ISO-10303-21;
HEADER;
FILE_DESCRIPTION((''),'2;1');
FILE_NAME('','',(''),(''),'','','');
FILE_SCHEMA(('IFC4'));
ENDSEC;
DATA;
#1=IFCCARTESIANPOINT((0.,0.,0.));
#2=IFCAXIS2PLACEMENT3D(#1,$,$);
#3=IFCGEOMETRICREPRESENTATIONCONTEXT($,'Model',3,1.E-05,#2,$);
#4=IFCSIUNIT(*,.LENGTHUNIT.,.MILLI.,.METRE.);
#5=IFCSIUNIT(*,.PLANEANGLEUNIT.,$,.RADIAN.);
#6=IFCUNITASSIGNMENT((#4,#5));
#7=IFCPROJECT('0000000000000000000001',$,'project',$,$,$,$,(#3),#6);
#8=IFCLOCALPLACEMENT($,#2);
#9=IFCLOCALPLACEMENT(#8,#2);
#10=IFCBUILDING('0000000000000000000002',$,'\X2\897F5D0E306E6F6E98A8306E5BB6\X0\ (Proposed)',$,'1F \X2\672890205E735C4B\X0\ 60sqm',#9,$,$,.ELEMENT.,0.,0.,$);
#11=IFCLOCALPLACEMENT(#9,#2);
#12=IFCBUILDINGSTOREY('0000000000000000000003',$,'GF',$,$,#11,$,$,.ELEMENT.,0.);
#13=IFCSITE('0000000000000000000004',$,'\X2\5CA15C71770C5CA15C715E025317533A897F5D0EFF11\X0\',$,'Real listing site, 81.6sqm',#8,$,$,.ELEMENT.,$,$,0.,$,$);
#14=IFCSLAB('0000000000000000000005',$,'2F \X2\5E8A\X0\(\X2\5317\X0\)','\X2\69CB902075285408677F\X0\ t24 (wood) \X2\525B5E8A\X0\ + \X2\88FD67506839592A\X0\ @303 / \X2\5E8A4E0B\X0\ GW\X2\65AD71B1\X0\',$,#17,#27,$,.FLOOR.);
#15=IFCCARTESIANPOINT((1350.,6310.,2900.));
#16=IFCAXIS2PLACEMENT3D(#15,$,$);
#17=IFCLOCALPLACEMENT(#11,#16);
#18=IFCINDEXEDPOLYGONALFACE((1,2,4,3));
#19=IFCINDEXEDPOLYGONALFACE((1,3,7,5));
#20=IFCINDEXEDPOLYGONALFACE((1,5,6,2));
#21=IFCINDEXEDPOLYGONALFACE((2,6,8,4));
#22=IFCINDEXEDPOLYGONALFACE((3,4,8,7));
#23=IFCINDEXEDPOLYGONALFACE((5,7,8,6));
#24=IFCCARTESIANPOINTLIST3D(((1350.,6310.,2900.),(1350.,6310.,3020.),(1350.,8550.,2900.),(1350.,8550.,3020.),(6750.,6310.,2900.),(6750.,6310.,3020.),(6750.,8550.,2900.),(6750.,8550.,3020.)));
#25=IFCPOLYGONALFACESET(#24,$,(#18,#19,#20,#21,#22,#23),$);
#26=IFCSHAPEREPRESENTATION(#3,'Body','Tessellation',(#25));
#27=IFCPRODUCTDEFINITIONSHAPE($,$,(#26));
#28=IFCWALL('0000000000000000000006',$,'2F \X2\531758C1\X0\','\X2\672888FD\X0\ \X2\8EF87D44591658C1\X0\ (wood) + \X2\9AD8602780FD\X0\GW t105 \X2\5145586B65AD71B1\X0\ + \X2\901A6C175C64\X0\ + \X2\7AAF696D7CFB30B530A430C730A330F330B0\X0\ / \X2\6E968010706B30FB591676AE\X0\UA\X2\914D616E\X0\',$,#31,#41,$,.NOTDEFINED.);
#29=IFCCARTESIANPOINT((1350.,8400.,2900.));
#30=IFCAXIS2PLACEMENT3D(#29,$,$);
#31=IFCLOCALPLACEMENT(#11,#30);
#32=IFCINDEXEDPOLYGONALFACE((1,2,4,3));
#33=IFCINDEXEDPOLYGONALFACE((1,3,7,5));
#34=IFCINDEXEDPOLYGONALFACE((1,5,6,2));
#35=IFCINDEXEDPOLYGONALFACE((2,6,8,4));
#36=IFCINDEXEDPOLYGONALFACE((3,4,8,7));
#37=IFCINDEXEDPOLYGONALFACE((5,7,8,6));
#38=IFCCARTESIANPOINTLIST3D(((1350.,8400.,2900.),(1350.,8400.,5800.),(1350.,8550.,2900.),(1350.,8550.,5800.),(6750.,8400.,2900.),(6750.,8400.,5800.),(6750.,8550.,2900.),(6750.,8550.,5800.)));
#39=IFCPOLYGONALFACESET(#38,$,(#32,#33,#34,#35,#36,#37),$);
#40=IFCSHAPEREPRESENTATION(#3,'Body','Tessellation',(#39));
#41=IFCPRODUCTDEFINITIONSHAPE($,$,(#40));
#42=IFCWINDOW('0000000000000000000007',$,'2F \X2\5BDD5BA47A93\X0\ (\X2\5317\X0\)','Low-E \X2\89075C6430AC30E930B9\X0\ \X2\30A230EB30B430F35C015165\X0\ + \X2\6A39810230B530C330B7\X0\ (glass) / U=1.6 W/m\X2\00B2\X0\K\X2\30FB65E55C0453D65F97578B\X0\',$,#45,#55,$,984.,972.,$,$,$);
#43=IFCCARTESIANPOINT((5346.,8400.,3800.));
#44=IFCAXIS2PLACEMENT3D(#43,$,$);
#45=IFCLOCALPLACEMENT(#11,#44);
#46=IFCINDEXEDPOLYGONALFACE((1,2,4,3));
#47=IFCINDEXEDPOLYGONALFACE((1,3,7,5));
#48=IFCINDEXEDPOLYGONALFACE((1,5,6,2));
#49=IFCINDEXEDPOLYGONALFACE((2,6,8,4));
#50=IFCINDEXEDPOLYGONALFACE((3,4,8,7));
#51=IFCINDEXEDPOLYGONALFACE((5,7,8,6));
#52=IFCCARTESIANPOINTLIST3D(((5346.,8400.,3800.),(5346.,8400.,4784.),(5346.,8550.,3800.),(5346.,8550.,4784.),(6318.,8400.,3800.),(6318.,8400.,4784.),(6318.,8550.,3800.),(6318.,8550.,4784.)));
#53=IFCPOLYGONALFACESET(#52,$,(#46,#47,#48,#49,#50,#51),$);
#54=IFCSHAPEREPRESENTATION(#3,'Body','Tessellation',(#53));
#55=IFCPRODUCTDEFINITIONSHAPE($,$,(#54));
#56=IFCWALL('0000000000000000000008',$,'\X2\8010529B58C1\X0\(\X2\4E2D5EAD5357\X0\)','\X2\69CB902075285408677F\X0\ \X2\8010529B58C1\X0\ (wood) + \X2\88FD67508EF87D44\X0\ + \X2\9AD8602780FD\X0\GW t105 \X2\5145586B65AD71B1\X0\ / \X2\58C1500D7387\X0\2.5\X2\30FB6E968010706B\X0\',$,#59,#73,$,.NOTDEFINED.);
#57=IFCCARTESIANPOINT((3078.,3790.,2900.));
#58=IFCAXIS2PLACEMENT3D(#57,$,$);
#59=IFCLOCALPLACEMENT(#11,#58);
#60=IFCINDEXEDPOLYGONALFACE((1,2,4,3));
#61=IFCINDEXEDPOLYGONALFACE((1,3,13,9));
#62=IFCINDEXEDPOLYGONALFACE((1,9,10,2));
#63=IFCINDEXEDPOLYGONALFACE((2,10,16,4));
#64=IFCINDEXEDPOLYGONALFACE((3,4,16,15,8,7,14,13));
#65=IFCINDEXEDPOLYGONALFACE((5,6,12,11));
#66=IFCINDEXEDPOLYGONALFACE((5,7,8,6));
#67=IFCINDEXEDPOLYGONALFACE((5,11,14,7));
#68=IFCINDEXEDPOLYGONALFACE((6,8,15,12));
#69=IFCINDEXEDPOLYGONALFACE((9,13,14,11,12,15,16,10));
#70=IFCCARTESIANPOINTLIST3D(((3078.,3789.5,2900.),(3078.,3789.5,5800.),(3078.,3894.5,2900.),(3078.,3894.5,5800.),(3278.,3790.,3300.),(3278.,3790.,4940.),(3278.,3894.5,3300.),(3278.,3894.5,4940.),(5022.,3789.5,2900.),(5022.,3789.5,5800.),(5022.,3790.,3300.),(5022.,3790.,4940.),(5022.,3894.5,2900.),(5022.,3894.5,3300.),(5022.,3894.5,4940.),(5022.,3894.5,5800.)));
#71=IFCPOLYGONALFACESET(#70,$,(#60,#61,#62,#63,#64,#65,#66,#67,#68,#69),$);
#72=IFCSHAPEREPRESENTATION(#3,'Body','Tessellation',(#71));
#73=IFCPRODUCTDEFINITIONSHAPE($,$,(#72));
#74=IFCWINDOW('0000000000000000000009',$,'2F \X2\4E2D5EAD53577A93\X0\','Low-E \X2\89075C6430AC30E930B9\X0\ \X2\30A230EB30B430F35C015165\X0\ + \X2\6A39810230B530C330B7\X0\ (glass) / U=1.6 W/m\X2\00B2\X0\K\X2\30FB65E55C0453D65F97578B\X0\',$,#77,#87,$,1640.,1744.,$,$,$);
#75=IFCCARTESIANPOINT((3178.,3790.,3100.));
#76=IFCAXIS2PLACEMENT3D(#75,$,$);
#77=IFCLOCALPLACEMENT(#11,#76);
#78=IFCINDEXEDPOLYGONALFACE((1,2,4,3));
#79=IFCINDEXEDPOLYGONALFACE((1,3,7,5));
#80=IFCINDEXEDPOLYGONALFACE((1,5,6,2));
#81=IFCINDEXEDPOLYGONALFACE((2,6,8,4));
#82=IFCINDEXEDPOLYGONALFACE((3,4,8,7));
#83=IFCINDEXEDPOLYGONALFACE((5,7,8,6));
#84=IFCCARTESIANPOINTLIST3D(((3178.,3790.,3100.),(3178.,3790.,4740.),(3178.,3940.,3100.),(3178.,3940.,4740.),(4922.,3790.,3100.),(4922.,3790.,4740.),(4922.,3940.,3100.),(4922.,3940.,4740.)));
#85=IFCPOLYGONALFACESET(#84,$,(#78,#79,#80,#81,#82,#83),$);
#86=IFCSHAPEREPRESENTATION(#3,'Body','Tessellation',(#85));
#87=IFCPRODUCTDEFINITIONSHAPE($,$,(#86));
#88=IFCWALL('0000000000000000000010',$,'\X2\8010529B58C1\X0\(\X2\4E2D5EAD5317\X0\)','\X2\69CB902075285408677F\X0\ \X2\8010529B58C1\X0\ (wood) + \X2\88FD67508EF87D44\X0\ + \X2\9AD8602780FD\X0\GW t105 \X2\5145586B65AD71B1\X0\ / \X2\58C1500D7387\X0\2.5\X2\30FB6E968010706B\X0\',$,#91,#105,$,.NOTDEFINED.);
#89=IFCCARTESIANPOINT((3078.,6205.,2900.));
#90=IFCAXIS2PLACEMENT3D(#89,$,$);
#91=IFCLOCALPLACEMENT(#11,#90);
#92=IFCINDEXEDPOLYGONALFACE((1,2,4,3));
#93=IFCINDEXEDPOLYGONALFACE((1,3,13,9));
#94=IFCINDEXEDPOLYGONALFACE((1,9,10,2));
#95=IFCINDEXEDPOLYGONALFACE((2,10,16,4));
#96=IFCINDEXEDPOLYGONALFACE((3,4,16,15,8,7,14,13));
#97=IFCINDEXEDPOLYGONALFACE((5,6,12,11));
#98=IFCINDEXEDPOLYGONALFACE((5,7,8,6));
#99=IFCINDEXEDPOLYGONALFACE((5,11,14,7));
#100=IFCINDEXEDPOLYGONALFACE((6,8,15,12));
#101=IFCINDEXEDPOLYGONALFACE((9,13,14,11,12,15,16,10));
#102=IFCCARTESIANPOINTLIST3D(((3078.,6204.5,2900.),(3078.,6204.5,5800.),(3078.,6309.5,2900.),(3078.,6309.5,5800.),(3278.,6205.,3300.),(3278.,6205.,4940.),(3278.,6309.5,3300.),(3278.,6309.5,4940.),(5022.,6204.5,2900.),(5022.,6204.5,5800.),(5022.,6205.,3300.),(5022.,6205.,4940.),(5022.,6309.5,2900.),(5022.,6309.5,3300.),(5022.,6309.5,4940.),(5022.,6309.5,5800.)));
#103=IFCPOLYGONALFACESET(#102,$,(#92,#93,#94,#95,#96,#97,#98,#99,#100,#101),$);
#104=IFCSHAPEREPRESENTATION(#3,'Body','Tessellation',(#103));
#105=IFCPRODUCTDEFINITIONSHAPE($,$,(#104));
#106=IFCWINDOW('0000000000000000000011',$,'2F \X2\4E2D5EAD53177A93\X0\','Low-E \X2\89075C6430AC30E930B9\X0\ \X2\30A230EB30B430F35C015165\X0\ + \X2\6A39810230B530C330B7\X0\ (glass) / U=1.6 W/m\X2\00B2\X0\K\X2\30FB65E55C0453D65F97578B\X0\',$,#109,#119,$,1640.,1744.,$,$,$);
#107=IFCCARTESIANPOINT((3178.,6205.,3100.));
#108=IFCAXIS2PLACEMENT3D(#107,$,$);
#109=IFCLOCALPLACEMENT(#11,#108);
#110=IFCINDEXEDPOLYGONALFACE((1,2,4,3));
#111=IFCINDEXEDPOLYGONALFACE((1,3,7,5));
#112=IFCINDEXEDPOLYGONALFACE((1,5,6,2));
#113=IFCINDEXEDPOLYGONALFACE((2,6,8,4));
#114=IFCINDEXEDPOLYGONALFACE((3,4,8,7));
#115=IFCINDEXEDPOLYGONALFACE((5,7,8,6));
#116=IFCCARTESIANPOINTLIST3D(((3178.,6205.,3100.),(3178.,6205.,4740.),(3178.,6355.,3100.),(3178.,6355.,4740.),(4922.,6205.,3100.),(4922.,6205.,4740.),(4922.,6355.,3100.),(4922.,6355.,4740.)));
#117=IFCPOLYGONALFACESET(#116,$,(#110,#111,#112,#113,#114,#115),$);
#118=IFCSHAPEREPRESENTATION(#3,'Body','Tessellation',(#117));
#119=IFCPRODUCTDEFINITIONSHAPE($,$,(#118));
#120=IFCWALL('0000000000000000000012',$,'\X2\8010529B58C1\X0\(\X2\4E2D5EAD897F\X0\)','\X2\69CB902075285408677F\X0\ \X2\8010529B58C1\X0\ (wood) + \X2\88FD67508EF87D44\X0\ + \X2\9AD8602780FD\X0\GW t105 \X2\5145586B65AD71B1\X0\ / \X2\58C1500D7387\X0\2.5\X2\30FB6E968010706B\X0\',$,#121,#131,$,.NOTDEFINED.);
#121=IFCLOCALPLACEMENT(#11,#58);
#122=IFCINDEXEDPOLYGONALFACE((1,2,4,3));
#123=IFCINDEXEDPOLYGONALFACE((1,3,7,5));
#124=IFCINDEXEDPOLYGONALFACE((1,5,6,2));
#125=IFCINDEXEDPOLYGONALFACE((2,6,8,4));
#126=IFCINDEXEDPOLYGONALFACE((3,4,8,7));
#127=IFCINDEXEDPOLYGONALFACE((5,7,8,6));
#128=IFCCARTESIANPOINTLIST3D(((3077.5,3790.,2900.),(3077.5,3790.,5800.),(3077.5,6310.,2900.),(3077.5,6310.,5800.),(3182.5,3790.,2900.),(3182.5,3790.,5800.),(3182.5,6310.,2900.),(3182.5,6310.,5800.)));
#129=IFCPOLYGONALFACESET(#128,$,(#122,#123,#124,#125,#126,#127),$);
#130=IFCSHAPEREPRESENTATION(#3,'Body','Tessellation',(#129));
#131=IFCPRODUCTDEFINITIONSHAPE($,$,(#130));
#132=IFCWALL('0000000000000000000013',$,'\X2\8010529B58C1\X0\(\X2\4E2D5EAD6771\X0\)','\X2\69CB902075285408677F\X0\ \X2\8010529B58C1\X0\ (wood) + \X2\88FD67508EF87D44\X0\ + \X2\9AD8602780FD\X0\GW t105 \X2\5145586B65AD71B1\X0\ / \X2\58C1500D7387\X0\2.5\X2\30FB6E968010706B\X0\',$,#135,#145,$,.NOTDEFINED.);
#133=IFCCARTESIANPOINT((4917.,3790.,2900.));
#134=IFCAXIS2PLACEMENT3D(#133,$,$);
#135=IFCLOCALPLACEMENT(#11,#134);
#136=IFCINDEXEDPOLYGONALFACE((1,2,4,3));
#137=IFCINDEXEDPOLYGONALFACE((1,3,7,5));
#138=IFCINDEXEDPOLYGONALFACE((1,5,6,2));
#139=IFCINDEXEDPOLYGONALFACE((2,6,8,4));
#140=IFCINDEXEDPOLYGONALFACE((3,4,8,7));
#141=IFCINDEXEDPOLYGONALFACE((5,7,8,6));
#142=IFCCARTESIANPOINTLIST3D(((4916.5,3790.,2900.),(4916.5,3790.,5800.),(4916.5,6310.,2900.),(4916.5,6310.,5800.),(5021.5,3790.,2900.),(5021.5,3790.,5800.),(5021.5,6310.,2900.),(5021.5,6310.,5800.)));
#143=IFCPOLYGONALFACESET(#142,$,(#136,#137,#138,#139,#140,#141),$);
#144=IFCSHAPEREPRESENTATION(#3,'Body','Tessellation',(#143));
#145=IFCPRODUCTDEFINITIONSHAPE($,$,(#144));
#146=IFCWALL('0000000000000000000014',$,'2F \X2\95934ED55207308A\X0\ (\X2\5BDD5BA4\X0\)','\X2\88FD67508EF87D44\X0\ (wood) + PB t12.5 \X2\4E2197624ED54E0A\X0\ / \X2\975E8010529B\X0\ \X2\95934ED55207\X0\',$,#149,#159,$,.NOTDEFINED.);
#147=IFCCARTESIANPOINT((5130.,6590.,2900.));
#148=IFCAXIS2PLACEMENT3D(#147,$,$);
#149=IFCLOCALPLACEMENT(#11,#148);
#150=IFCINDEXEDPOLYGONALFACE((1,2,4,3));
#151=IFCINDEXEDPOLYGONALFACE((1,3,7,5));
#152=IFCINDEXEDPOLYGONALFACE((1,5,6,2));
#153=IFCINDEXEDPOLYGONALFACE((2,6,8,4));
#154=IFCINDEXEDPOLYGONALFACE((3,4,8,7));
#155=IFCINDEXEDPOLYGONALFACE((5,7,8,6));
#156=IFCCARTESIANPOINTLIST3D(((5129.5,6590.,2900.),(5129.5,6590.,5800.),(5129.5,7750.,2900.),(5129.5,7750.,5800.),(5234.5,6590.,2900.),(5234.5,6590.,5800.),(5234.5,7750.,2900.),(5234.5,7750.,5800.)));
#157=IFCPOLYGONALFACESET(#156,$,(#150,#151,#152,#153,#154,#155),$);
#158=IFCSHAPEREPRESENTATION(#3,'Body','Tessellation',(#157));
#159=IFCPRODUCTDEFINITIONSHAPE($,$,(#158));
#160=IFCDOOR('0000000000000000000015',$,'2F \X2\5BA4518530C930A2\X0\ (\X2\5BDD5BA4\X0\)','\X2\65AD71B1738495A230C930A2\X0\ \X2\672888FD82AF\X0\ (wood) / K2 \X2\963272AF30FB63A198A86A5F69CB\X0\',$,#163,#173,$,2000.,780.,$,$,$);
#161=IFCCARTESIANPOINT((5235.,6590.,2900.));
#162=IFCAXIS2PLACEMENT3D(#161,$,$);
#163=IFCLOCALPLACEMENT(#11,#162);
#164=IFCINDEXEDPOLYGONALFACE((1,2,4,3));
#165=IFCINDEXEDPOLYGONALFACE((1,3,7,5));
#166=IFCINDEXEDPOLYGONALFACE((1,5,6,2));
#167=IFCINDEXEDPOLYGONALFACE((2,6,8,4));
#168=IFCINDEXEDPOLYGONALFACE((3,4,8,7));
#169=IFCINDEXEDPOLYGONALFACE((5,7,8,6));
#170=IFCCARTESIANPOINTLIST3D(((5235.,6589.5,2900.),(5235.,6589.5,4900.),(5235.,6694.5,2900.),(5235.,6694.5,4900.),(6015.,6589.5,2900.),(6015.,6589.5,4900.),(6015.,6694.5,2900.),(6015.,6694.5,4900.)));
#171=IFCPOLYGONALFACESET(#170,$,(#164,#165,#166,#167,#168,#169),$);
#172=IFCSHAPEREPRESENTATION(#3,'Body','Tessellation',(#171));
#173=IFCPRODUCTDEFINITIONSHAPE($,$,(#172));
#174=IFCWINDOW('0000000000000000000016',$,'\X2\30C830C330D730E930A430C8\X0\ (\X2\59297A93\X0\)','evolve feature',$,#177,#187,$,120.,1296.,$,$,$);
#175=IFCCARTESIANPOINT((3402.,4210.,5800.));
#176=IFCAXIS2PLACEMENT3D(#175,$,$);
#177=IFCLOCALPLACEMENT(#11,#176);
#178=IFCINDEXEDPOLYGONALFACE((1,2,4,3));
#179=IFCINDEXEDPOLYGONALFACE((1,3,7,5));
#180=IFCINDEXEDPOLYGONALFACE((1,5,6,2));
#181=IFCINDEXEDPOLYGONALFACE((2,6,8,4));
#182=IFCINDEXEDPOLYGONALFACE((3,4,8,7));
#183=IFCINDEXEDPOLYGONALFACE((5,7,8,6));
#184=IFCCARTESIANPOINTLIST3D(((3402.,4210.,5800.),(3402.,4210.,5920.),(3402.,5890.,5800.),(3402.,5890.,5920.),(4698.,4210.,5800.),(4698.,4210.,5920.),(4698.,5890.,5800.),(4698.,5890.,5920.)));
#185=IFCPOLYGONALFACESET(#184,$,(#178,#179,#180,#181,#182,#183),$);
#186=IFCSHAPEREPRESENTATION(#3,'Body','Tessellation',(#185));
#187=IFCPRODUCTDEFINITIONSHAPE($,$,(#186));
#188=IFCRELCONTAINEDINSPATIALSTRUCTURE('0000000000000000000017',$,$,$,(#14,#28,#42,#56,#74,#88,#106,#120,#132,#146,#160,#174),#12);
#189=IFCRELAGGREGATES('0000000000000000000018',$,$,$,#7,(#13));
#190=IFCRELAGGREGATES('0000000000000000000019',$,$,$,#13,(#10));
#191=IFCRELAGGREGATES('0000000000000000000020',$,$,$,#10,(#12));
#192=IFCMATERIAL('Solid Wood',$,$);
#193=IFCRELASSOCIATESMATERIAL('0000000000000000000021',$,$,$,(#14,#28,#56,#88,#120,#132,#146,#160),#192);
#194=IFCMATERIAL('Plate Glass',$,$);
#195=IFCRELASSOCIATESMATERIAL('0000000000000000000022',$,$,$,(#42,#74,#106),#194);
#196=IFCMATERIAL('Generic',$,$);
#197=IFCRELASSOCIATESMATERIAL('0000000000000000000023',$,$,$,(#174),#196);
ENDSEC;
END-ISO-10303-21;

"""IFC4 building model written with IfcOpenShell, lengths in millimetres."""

from ifc_helpers import new_model, si_unit, frame, frame_2d, origin, place, context, project, spatial, rectangle, extrude, material, element, fill, save


model = new_model("IFC4")

# Units and contexts
model_context = context("Model", 3, precision=1e-05, world=origin())
ifc_project = project(units=[si_unit("LENGTHUNIT", "METRE", prefix="MILLI"), si_unit("PLANEANGLEUNIT", "RADIAN")], contexts=[model_context])

# Site, building, storey
site_placement = place(None, origin())
site = spatial("IfcSite", under=ifc_project, at=site_placement, Name="岡山県岡山市北区西崎１", ObjectType="Real listing site, 81.6sqm", CompositionType="ELEMENT", RefElevation=0.0)
building_placement = place(site_placement, origin())
building = spatial("IfcBuilding", under=site, at=building_placement, Name="西崎の潮風の家 (Proposed)", ObjectType="1F 木造平屋 60sqm", CompositionType="ELEMENT", ElevationOfRefHeight=0.0, ElevationOfTerrain=0.0)
storey_placement = place(building_placement, origin())
storey = spatial("IfcBuildingStorey", under=building, at=storey_placement, Name="GF", CompositionType="ELEMENT", Elevation=0.0)

# Slab
ifc_material_1 = material(Name="Solid Wood")
slab_placement = place(storey_placement, frame((1350.0, 6310.0, 2900.0)))
element("IfcSlab", 1, at=slab_placement, inside=storey, material=ifc_material_1, Name="2F 床(北)", Description="構造用合板 t24 (wood) 剛床 + 製材根太 @303 / 床下 GW断熱", PredefinedType="FLOOR", context=model_context, shape_type="SweptSolid", body=[
    extrude(rectangle(XDim=5400.0, YDim=2240.0, at=frame_2d((2700.0, 1120.0))), frame((1350.0, 6310.0, 2900.0)), (0.0, 0.0, 1.0), 120.0),
])

# Walls, openings, windows
wall_1_placement = place(storey_placement, frame((1350.0, 8400.0, 2900.0)))
wall_1 = element("IfcWall", 2, at=wall_1_placement, inside=storey, material=ifc_material_1, Name="2F 北壁", Description="木製 軸組外壁 (wood) + 高性能GW t105 充填断熱 + 通気層 + 窯業系サイディング / 準耐火・外皮UA配慮", PredefinedType="NOTDEFINED", context=model_context, shape_type="SweptSolid", body=[
    extrude(rectangle(XDim=5400.0, YDim=150.0, at=frame_2d((2700.0, 75.0))), frame((1350.0, 8400.0, 2900.0)), (0.0, 0.0, 1.0), 2900.0),
])
opening_1_placement = place(storey_placement, frame((5346.0, 8400.0, 3800.0)))
opening_1 = element("IfcOpeningElement", 3, at=opening_1_placement, cuts=wall_1, PredefinedType="NOTDEFINED", context=model_context, shape_type="SweptSolid", body=[
    extrude(rectangle(XDim=972.0, YDim=150.0, at=frame_2d((486.0, 75.0))), frame((5346.0, 8400.0, 3800.0)), (0.0, 0.0, 1.0), 984.0),
])
ifc_material_2 = material(Name="Plate Glass")
window_1_placement = place(storey_placement, frame((5346.0, 8400.0, 3800.0)))
window_1 = element("IfcWindow", 4, at=window_1_placement, inside=storey, material=ifc_material_2, Name="2F 寝室窓 (北)", Description="Low-E 複層ガラス アルゴン封入 + 樹脂サッシ (glass) / U=1.6 W/m²K・日射取得型", OverallHeight=984.0, OverallWidth=972.0, context=model_context, shape_type="SweptSolid", body=[
    extrude(rectangle(XDim=972.0, YDim=150.0, at=frame_2d((486.0, 75.0))), frame((5346.0, 8400.0, 3800.0)), (0.0, 0.0, 1.0), 984.0),
])
fill(opening_1, window_1)
wall_2_placement = place(storey_placement, frame((3078.0, 3790.0, 2900.0)))
wall_2 = element("IfcWall", 5, at=wall_2_placement, inside=storey, material=ifc_material_1, Name="耐力壁(中庭南)", Description="構造用合板 耐力壁 (wood) + 製材軸組 + 高性能GW t105 充填断熱 / 壁倍率2.5・準耐火", PredefinedType="NOTDEFINED", context=model_context, shape_type="SweptSolid", body=[
    extrude(rectangle(XDim=1944.0, YDim=105.0, at=frame_2d((972.0, 52.0))), frame((3078.0, 3790.0, 2900.0)), (0.0, 0.0, 1.0), 2900.0),
])
opening_2_placement = place(storey_placement, frame((3178.0, 3790.0, 3100.0)))
opening_2 = element("IfcOpeningElement", 6, at=opening_2_placement, cuts=wall_2, PredefinedType="NOTDEFINED", context=model_context, shape_type="SweptSolid", body=[
    extrude(rectangle(XDim=1744.0, YDim=150.0, at=frame_2d((872.0, 75.0))), frame((3178.0, 3790.0, 3100.0)), (0.0, 0.0, 1.0), 1640.0),
])
window_2_placement = place(storey_placement, frame((3178.0, 3790.0, 3100.0)))
window_2 = element("IfcWindow", 7, at=window_2_placement, inside=storey, material=ifc_material_2, Name="2F 中庭南窓", Description="Low-E 複層ガラス アルゴン封入 + 樹脂サッシ (glass) / U=1.6 W/m²K・日射取得型", OverallHeight=1640.0, OverallWidth=1744.0, context=model_context, shape_type="SweptSolid", body=[
    extrude(rectangle(XDim=1744.0, YDim=150.0, at=frame_2d((872.0, 75.0))), frame((3178.0, 3790.0, 3100.0)), (0.0, 0.0, 1.0), 1640.0),
])
fill(opening_2, window_2)
wall_3_placement = place(storey_placement, frame((3078.0, 6205.0, 2900.0)))
wall_3 = element("IfcWall", 8, at=wall_3_placement, inside=storey, material=ifc_material_1, Name="耐力壁(中庭北)", Description="構造用合板 耐力壁 (wood) + 製材軸組 + 高性能GW t105 充填断熱 / 壁倍率2.5・準耐火", PredefinedType="NOTDEFINED", context=model_context, shape_type="SweptSolid", body=[
    extrude(rectangle(XDim=1944.0, YDim=105.0, at=frame_2d((972.0, 52.0))), frame((3078.0, 6205.0, 2900.0)), (0.0, 0.0, 1.0), 2900.0),
])
opening_3_placement = place(storey_placement, frame((3178.0, 6205.0, 3100.0)))
opening_3 = element("IfcOpeningElement", 9, at=opening_3_placement, cuts=wall_3, PredefinedType="NOTDEFINED", context=model_context, shape_type="SweptSolid", body=[
    extrude(rectangle(XDim=1744.0, YDim=150.0, at=frame_2d((872.0, 75.0))), frame((3178.0, 6205.0, 3100.0)), (0.0, 0.0, 1.0), 1640.0),
])
window_3_placement = place(storey_placement, frame((3178.0, 6205.0, 3100.0)))
window_3 = element("IfcWindow", 10, at=window_3_placement, inside=storey, material=ifc_material_2, Name="2F 中庭北窓", Description="Low-E 複層ガラス アルゴン封入 + 樹脂サッシ (glass) / U=1.6 W/m²K・日射取得型", OverallHeight=1640.0, OverallWidth=1744.0, context=model_context, shape_type="SweptSolid", body=[
    extrude(rectangle(XDim=1744.0, YDim=150.0, at=frame_2d((872.0, 75.0))), frame((3178.0, 6205.0, 3100.0)), (0.0, 0.0, 1.0), 1640.0),
])
fill(opening_3, window_3)

# Walls
wall_4_placement = place(storey_placement, frame((3078.0, 3790.0, 2900.0)))
element("IfcWall", 11, at=wall_4_placement, inside=storey, material=ifc_material_1, Name="耐力壁(中庭西)", Description="構造用合板 耐力壁 (wood) + 製材軸組 + 高性能GW t105 充填断熱 / 壁倍率2.5・準耐火", PredefinedType="NOTDEFINED", context=model_context, shape_type="SweptSolid", body=[
    extrude(rectangle(XDim=105.0, YDim=2520.0, at=frame_2d((52.0, 1260.0))), frame((3078.0, 3790.0, 2900.0)), (0.0, 0.0, 1.0), 2900.0),
])
wall_5_placement = place(storey_placement, frame((4917.0, 3790.0, 2900.0)))
element("IfcWall", 12, at=wall_5_placement, inside=storey, material=ifc_material_1, Name="耐力壁(中庭東)", Description="構造用合板 耐力壁 (wood) + 製材軸組 + 高性能GW t105 充填断熱 / 壁倍率2.5・準耐火", PredefinedType="NOTDEFINED", context=model_context, shape_type="SweptSolid", body=[
    extrude(rectangle(XDim=105.0, YDim=2520.0, at=frame_2d((52.0, 1260.0))), frame((4917.0, 3790.0, 2900.0)), (0.0, 0.0, 1.0), 2900.0),
])
wall_6_placement = place(storey_placement, frame((5130.0, 6590.0, 2900.0)))
element("IfcWall", 13, at=wall_6_placement, inside=storey, material=ifc_material_1, Name="2F 間仕切り (寝室)", Description="製材軸組 (wood) + PB t12.5 両面仕上 / 非耐力 間仕切", PredefinedType="NOTDEFINED", context=model_context, shape_type="SweptSolid", body=[
    extrude(rectangle(XDim=105.0, YDim=1160.0, at=frame_2d((52.0, 580.0))), frame((5130.0, 6590.0, 2900.0)), (0.0, 0.0, 1.0), 2900.0),
])

# Door
door_placement = place(storey_placement, frame((5235.0, 6590.0, 2900.0)))
element("IfcDoor", 14, at=door_placement, inside=storey, material=ifc_material_1, Name="2F 室内ドア (寝室)", Description="断熱玄関ドア 木製芯 (wood) / K2 防犯・採風機構", OverallHeight=2000.0, OverallWidth=780.0, context=model_context, shape_type="SweptSolid", body=[
    extrude(rectangle(XDim=780.0, YDim=105.0, at=frame_2d((390.0, 52.0))), frame((5235.0, 6590.0, 2900.0)), (0.0, 0.0, 1.0), 2000.0),
])

# Window
ifc_material_3 = material(Name="Generic")
window_4_placement = place(storey_placement, frame((3402.0, 4210.0, 5800.0)))
element("IfcWindow", 15, at=window_4_placement, inside=storey, material=ifc_material_3, Name="トップライト (天窓)", Description="evolve feature", OverallHeight=120.0, OverallWidth=1296.0, context=model_context, shape_type="SweptSolid", body=[
    extrude(rectangle(XDim=1296.0, YDim=1680.0, at=frame_2d((648.0, 840.0))), frame((3402.0, 4210.0, 5800.0)), (0.0, 0.0, 1.0), 120.0),
])

save(model, "model.ifc")
